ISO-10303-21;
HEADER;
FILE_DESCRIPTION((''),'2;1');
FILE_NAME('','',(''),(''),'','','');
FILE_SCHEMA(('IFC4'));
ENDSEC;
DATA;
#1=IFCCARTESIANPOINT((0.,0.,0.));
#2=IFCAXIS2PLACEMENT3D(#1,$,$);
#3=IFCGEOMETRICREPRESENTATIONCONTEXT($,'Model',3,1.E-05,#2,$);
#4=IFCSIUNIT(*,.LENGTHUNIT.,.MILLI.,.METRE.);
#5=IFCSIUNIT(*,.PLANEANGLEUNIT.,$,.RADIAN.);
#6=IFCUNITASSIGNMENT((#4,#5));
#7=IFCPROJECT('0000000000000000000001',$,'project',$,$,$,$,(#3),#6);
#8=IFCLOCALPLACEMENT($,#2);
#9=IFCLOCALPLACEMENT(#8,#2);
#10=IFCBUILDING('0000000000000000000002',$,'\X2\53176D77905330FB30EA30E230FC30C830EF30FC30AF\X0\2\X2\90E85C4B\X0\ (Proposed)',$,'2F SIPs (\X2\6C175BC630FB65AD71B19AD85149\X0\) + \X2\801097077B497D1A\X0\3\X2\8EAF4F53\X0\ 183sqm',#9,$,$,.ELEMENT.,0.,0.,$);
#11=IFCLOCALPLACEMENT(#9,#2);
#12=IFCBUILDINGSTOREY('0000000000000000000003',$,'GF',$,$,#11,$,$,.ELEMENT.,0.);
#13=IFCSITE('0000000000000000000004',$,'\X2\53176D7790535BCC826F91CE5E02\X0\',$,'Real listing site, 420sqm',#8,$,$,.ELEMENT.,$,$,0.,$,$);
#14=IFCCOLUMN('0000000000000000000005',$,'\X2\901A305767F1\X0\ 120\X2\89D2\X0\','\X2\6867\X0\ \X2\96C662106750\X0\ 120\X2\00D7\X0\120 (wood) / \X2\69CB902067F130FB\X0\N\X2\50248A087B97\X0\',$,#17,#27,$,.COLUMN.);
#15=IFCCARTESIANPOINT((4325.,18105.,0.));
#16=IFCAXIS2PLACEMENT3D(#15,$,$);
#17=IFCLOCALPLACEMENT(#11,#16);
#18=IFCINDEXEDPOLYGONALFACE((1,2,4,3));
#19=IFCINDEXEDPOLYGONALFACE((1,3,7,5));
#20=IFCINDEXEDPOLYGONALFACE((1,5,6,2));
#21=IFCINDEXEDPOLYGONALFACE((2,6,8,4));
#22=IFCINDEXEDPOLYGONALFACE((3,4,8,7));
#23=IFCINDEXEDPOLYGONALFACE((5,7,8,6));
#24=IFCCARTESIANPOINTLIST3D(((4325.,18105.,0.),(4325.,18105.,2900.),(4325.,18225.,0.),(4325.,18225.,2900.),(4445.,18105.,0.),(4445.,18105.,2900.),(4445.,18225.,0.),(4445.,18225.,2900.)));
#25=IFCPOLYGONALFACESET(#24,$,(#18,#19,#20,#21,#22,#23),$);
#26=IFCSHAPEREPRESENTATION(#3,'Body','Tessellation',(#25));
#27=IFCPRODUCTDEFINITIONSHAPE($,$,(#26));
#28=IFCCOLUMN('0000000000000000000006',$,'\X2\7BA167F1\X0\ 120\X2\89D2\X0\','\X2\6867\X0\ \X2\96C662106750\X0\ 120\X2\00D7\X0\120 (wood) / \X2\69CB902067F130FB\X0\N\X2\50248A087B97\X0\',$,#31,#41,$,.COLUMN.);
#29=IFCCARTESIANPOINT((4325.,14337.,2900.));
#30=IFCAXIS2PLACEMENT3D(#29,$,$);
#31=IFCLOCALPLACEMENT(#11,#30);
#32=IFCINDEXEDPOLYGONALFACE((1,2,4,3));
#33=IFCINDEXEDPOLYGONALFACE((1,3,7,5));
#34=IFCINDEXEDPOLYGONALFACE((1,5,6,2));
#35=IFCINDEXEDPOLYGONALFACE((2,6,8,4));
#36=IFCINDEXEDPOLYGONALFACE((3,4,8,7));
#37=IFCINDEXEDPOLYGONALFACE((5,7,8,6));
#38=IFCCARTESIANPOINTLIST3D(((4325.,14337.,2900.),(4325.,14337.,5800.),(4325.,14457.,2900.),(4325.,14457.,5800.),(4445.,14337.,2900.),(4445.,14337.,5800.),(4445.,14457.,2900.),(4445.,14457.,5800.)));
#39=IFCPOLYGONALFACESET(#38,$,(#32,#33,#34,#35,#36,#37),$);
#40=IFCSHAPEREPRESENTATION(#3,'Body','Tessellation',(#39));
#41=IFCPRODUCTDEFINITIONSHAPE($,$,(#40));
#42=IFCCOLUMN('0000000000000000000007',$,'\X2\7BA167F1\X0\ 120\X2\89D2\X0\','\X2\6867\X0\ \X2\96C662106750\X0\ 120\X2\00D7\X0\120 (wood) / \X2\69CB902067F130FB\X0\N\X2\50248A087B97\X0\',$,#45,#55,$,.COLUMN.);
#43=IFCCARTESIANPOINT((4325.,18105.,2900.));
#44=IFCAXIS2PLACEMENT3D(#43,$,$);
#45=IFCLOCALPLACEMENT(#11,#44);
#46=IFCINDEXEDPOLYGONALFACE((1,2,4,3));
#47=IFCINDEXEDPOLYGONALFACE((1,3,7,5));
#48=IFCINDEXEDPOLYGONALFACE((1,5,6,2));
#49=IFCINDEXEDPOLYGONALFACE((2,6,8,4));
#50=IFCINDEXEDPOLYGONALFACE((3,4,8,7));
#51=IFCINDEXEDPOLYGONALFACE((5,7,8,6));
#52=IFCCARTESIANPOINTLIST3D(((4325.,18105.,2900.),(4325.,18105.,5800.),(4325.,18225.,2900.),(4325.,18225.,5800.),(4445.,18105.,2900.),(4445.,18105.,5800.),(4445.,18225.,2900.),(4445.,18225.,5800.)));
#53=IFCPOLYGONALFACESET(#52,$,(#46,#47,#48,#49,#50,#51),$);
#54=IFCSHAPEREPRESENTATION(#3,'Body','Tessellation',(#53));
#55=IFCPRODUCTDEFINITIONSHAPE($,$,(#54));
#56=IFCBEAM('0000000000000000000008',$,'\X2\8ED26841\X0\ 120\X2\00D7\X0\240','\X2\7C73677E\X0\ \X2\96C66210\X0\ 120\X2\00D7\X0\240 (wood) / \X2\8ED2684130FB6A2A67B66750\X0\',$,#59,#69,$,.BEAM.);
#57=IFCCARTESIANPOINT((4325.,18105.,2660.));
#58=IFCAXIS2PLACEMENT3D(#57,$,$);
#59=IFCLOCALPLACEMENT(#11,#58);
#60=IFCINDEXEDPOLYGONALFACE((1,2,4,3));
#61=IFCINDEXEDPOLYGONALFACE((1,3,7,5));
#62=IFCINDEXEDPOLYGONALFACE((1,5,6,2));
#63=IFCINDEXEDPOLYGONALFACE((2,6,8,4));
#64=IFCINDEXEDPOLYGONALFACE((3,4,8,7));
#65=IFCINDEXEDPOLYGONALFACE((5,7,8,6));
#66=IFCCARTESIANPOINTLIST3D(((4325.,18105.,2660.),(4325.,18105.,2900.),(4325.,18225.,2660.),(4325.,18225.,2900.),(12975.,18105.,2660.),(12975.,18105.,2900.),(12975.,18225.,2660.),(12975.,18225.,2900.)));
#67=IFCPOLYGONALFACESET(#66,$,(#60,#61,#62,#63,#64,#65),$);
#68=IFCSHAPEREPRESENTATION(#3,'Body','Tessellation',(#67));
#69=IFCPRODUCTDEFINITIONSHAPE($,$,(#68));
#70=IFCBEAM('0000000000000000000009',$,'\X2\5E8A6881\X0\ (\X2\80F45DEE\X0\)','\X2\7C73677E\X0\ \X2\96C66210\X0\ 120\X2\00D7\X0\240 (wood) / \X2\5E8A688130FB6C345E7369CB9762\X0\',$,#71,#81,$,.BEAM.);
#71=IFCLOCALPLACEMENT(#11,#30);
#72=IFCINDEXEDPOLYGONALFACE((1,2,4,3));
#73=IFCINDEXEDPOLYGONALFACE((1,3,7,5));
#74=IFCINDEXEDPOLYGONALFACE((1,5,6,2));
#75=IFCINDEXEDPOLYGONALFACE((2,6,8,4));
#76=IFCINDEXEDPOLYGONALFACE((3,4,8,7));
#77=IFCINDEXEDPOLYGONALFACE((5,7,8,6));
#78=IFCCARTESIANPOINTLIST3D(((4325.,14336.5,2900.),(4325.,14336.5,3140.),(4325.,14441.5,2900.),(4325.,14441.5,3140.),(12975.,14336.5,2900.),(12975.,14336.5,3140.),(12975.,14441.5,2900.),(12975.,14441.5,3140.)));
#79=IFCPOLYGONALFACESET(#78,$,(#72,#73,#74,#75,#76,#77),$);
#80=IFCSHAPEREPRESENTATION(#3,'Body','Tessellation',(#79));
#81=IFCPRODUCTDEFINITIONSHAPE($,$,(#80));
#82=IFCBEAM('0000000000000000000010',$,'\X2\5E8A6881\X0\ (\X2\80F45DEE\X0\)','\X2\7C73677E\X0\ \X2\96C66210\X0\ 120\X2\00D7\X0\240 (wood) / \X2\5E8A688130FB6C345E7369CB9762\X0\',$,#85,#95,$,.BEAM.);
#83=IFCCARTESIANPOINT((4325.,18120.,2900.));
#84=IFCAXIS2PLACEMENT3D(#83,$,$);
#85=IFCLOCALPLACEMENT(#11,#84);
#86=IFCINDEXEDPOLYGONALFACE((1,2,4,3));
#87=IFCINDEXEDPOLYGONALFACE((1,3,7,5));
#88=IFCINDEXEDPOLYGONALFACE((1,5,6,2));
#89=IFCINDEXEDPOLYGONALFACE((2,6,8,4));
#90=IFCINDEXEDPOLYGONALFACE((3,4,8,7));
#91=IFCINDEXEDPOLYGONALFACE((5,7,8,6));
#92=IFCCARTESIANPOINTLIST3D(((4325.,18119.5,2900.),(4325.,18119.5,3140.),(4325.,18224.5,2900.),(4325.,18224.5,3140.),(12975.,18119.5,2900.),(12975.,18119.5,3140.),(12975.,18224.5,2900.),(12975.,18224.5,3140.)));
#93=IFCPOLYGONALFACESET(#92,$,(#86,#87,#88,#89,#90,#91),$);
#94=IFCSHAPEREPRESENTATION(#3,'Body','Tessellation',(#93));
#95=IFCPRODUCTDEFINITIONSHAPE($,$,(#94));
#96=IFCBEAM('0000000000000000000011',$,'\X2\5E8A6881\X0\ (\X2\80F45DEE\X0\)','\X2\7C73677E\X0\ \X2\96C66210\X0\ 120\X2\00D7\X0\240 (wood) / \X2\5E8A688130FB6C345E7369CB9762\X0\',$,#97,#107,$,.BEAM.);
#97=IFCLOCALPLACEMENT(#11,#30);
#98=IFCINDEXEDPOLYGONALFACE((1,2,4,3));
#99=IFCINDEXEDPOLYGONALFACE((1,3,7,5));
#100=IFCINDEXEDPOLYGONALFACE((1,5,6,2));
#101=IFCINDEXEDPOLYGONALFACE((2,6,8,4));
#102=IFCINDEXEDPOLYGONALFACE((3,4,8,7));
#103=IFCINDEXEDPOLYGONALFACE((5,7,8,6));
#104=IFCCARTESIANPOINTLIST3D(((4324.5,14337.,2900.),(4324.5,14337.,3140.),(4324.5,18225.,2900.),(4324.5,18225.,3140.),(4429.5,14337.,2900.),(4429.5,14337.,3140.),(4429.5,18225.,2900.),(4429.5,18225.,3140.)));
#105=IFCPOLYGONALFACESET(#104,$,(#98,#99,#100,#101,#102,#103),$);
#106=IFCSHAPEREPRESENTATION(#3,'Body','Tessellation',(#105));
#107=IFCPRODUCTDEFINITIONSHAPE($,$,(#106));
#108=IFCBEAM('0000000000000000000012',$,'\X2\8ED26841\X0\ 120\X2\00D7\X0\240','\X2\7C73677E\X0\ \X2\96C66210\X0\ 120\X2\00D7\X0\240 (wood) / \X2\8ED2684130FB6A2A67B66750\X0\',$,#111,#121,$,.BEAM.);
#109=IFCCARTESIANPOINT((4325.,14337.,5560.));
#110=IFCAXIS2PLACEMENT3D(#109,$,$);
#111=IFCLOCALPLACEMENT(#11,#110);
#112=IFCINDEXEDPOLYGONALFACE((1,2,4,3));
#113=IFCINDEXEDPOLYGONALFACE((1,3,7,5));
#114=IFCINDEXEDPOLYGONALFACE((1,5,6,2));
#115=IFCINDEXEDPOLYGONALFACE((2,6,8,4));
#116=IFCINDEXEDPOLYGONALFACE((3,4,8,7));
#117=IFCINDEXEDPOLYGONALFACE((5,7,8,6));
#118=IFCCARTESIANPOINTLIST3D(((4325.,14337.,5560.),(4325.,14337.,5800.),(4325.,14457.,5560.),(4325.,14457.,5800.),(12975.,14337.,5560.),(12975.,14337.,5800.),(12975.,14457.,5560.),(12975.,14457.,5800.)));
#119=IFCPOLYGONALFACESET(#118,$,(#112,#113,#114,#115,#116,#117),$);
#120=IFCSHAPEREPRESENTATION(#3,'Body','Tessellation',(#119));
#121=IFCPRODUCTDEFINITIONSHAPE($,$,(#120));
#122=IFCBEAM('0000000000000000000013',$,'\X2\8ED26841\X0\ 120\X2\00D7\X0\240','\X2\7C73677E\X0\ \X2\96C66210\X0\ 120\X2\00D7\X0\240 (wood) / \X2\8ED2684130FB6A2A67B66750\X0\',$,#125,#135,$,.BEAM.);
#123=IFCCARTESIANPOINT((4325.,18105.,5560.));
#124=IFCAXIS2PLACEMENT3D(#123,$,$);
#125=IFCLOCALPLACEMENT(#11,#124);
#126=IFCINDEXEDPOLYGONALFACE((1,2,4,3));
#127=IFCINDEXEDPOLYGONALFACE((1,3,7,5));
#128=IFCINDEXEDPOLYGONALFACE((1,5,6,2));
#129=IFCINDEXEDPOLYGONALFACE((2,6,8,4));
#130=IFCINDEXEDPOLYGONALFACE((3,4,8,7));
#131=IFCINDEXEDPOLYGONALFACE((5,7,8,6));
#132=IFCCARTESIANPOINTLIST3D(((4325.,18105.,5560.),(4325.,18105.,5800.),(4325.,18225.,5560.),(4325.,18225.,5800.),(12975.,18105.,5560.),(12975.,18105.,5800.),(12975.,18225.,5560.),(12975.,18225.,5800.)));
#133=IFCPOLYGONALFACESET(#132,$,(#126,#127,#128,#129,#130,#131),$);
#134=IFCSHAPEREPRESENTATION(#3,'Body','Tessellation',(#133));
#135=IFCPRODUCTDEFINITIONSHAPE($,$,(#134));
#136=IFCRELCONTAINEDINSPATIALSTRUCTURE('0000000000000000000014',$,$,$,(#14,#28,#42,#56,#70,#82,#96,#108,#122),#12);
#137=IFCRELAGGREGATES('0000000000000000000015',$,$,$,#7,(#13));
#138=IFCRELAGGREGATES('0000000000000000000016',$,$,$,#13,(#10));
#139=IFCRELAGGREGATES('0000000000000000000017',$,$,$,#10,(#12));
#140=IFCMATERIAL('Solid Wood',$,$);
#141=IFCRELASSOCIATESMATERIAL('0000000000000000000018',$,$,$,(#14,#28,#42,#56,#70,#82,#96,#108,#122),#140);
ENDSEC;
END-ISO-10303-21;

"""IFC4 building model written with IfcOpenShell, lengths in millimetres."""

from ifc_helpers import new_model, si_unit, frame, frame_2d, origin, place, context, project, spatial, rectangle, extrude, material, element, save


model = new_model("IFC4")

# Units and contexts
model_context = context("Model", 3, precision=1e-05, world=origin())
ifc_project = project(units=[si_unit("LENGTHUNIT", "METRE", prefix="MILLI"), si_unit("PLANEANGLEUNIT", "RADIAN")], contexts=[model_context])

# Site, building, storey
site_placement = place(None, origin())
site = spatial("IfcSite", under=ifc_project, at=site_placement, Name="北海道富良野市", ObjectType="Real listing site, 420sqm", CompositionType="ELEMENT", RefElevation=0.0)
building_placement = place(site_placement, origin())
building = spatial("IfcBuilding", under=site, at=building_placement, Name="北海道・リモートワーク2部屋 (Proposed)", ObjectType="2F SIPs (気密・断熱高光) + 耐震等級3躯体 183sqm", CompositionType="ELEMENT", ElevationOfRefHeight=0.0, ElevationOfTerrain=0.0)
storey_placement = place(building_placement, origin())
storey = spatial("IfcBuildingStorey", under=building, at=storey_placement, Name="GF", CompositionType="ELEMENT", Elevation=0.0)

# Columns
ifc_material_1 = material(Name="Solid Wood")
column_1_placement = place(storey_placement, frame((4325.0, 18105.0, 0.0)))
element("IfcColumn", 1, at=column_1_placement, inside=storey, material=ifc_material_1, Name="通し柱 120角", Description="桧 集成材 120×120 (wood) / 構造柱・N値計算", PredefinedType="COLUMN", context=model_context, shape_type="SweptSolid", body=[
    extrude(rectangle(XDim=120.0, YDim=120.0, at=frame_2d((60.0, 60.0))), frame((4325.0, 18105.0, 0.0)), (0.0, 0.0, 1.0), 2900.0),
])
column_2_placement = place(storey_placement, frame((4325.0, 14337.0, 2900.0)))
element("IfcColumn", 2, at=column_2_placement, inside=storey, material=ifc_material_1, Name="管柱 120角", Description="桧 集成材 120×120 (wood) / 構造柱・N値計算", PredefinedType="COLUMN", context=model_context, shape_type="SweptSolid", body=[
    extrude(rectangle(XDim=120.0, YDim=120.0, at=frame_2d((60.0, 60.0))), frame((4325.0, 14337.0, 2900.0)), (0.0, 0.0, 1.0), 2900.0),
])
column_3_placement = place(storey_placement, frame((4325.0, 18105.0, 2900.0)))
element("IfcColumn", 3, at=column_3_placement, inside=storey, material=ifc_material_1, Name="管柱 120角", Description="桧 集成材 120×120 (wood) / 構造柱・N値計算", PredefinedType="COLUMN", context=model_context, shape_type="SweptSolid", body=[
    extrude(rectangle(XDim=120.0, YDim=120.0, at=frame_2d((60.0, 60.0))), frame((4325.0, 18105.0, 2900.0)), (0.0, 0.0, 1.0), 2900.0),
])

# Beams
beam_1_placement = place(storey_placement, frame((4325.0, 18105.0, 2660.0)))
element("IfcBeam", 4, at=beam_1_placement, inside=storey, material=ifc_material_1, Name="軒桁 120×240", Description="米松 集成 120×240 (wood) / 軒桁・横架材", PredefinedType="BEAM", context=model_context, shape_type="SweptSolid", body=[
    extrude(rectangle(XDim=8650.0, YDim=120.0, at=frame_2d((4325.0, 60.0))), frame((4325.0, 18105.0, 2660.0)), (0.0, 0.0, 1.0), 240.0),
])
beam_2_placement = place(storey_placement, frame((4325.0, 14337.0, 2900.0)))
element("IfcBeam", 5, at=beam_2_placement, inside=storey, material=ifc_material_1, Name="床梁 (胴差)", Description="米松 集成 120×240 (wood) / 床梁・水平構面", PredefinedType="BEAM", context=model_context, shape_type="SweptSolid", body=[
    extrude(rectangle(XDim=8650.0, YDim=105.0, at=frame_2d((4325.0, 52.0))), frame((4325.0, 14337.0, 2900.0)), (0.0, 0.0, 1.0), 240.0),
])
beam_3_placement = place(storey_placement, frame((4325.0, 18120.0, 2900.0)))
element("IfcBeam", 6, at=beam_3_placement, inside=storey, material=ifc_material_1, Name="床梁 (胴差)", Description="米松 集成 120×240 (wood) / 床梁・水平構面", PredefinedType="BEAM", context=model_context, shape_type="SweptSolid", body=[
    extrude(rectangle(XDim=8650.0, YDim=105.0, at=frame_2d((4325.0, 52.0))), frame((4325.0, 18120.0, 2900.0)), (0.0, 0.0, 1.0), 240.0),
])
beam_4_placement = place(storey_placement, frame((4325.0, 14337.0, 2900.0)))
element("IfcBeam", 7, at=beam_4_placement, inside=storey, material=ifc_material_1, Name="床梁 (胴差)", Description="米松 集成 120×240 (wood) / 床梁・水平構面", PredefinedType="BEAM", context=model_context, shape_type="SweptSolid", body=[
    extrude(rectangle(XDim=105.0, YDim=3888.0, at=frame_2d((52.0, 1944.0))), frame((4325.0, 14337.0, 2900.0)), (0.0, 0.0, 1.0), 240.0),
])
beam_5_placement = place(storey_placement, frame((4325.0, 14337.0, 5560.0)))
element("IfcBeam", 8, at=beam_5_placement, inside=storey, material=ifc_material_1, Name="軒桁 120×240", Description="米松 集成 120×240 (wood) / 軒桁・横架材", PredefinedType="BEAM", context=model_context, shape_type="SweptSolid", body=[
    extrude(rectangle(XDim=8650.0, YDim=120.0, at=frame_2d((4325.0, 60.0))), frame((4325.0, 14337.0, 5560.0)), (0.0, 0.0, 1.0), 240.0),
])
beam_6_placement = place(storey_placement, frame((4325.0, 18105.0, 5560.0)))
element("IfcBeam", 9, at=beam_6_placement, inside=storey, material=ifc_material_1, Name="軒桁 120×240", Description="米松 集成 120×240 (wood) / 軒桁・横架材", PredefinedType="BEAM", context=model_context, shape_type="SweptSolid", body=[
    extrude(rectangle(XDim=8650.0, YDim=120.0, at=frame_2d((4325.0, 60.0))), frame((4325.0, 18105.0, 5560.0)), (0.0, 0.0, 1.0), 240.0),
])

save(model, "model.ifc")
